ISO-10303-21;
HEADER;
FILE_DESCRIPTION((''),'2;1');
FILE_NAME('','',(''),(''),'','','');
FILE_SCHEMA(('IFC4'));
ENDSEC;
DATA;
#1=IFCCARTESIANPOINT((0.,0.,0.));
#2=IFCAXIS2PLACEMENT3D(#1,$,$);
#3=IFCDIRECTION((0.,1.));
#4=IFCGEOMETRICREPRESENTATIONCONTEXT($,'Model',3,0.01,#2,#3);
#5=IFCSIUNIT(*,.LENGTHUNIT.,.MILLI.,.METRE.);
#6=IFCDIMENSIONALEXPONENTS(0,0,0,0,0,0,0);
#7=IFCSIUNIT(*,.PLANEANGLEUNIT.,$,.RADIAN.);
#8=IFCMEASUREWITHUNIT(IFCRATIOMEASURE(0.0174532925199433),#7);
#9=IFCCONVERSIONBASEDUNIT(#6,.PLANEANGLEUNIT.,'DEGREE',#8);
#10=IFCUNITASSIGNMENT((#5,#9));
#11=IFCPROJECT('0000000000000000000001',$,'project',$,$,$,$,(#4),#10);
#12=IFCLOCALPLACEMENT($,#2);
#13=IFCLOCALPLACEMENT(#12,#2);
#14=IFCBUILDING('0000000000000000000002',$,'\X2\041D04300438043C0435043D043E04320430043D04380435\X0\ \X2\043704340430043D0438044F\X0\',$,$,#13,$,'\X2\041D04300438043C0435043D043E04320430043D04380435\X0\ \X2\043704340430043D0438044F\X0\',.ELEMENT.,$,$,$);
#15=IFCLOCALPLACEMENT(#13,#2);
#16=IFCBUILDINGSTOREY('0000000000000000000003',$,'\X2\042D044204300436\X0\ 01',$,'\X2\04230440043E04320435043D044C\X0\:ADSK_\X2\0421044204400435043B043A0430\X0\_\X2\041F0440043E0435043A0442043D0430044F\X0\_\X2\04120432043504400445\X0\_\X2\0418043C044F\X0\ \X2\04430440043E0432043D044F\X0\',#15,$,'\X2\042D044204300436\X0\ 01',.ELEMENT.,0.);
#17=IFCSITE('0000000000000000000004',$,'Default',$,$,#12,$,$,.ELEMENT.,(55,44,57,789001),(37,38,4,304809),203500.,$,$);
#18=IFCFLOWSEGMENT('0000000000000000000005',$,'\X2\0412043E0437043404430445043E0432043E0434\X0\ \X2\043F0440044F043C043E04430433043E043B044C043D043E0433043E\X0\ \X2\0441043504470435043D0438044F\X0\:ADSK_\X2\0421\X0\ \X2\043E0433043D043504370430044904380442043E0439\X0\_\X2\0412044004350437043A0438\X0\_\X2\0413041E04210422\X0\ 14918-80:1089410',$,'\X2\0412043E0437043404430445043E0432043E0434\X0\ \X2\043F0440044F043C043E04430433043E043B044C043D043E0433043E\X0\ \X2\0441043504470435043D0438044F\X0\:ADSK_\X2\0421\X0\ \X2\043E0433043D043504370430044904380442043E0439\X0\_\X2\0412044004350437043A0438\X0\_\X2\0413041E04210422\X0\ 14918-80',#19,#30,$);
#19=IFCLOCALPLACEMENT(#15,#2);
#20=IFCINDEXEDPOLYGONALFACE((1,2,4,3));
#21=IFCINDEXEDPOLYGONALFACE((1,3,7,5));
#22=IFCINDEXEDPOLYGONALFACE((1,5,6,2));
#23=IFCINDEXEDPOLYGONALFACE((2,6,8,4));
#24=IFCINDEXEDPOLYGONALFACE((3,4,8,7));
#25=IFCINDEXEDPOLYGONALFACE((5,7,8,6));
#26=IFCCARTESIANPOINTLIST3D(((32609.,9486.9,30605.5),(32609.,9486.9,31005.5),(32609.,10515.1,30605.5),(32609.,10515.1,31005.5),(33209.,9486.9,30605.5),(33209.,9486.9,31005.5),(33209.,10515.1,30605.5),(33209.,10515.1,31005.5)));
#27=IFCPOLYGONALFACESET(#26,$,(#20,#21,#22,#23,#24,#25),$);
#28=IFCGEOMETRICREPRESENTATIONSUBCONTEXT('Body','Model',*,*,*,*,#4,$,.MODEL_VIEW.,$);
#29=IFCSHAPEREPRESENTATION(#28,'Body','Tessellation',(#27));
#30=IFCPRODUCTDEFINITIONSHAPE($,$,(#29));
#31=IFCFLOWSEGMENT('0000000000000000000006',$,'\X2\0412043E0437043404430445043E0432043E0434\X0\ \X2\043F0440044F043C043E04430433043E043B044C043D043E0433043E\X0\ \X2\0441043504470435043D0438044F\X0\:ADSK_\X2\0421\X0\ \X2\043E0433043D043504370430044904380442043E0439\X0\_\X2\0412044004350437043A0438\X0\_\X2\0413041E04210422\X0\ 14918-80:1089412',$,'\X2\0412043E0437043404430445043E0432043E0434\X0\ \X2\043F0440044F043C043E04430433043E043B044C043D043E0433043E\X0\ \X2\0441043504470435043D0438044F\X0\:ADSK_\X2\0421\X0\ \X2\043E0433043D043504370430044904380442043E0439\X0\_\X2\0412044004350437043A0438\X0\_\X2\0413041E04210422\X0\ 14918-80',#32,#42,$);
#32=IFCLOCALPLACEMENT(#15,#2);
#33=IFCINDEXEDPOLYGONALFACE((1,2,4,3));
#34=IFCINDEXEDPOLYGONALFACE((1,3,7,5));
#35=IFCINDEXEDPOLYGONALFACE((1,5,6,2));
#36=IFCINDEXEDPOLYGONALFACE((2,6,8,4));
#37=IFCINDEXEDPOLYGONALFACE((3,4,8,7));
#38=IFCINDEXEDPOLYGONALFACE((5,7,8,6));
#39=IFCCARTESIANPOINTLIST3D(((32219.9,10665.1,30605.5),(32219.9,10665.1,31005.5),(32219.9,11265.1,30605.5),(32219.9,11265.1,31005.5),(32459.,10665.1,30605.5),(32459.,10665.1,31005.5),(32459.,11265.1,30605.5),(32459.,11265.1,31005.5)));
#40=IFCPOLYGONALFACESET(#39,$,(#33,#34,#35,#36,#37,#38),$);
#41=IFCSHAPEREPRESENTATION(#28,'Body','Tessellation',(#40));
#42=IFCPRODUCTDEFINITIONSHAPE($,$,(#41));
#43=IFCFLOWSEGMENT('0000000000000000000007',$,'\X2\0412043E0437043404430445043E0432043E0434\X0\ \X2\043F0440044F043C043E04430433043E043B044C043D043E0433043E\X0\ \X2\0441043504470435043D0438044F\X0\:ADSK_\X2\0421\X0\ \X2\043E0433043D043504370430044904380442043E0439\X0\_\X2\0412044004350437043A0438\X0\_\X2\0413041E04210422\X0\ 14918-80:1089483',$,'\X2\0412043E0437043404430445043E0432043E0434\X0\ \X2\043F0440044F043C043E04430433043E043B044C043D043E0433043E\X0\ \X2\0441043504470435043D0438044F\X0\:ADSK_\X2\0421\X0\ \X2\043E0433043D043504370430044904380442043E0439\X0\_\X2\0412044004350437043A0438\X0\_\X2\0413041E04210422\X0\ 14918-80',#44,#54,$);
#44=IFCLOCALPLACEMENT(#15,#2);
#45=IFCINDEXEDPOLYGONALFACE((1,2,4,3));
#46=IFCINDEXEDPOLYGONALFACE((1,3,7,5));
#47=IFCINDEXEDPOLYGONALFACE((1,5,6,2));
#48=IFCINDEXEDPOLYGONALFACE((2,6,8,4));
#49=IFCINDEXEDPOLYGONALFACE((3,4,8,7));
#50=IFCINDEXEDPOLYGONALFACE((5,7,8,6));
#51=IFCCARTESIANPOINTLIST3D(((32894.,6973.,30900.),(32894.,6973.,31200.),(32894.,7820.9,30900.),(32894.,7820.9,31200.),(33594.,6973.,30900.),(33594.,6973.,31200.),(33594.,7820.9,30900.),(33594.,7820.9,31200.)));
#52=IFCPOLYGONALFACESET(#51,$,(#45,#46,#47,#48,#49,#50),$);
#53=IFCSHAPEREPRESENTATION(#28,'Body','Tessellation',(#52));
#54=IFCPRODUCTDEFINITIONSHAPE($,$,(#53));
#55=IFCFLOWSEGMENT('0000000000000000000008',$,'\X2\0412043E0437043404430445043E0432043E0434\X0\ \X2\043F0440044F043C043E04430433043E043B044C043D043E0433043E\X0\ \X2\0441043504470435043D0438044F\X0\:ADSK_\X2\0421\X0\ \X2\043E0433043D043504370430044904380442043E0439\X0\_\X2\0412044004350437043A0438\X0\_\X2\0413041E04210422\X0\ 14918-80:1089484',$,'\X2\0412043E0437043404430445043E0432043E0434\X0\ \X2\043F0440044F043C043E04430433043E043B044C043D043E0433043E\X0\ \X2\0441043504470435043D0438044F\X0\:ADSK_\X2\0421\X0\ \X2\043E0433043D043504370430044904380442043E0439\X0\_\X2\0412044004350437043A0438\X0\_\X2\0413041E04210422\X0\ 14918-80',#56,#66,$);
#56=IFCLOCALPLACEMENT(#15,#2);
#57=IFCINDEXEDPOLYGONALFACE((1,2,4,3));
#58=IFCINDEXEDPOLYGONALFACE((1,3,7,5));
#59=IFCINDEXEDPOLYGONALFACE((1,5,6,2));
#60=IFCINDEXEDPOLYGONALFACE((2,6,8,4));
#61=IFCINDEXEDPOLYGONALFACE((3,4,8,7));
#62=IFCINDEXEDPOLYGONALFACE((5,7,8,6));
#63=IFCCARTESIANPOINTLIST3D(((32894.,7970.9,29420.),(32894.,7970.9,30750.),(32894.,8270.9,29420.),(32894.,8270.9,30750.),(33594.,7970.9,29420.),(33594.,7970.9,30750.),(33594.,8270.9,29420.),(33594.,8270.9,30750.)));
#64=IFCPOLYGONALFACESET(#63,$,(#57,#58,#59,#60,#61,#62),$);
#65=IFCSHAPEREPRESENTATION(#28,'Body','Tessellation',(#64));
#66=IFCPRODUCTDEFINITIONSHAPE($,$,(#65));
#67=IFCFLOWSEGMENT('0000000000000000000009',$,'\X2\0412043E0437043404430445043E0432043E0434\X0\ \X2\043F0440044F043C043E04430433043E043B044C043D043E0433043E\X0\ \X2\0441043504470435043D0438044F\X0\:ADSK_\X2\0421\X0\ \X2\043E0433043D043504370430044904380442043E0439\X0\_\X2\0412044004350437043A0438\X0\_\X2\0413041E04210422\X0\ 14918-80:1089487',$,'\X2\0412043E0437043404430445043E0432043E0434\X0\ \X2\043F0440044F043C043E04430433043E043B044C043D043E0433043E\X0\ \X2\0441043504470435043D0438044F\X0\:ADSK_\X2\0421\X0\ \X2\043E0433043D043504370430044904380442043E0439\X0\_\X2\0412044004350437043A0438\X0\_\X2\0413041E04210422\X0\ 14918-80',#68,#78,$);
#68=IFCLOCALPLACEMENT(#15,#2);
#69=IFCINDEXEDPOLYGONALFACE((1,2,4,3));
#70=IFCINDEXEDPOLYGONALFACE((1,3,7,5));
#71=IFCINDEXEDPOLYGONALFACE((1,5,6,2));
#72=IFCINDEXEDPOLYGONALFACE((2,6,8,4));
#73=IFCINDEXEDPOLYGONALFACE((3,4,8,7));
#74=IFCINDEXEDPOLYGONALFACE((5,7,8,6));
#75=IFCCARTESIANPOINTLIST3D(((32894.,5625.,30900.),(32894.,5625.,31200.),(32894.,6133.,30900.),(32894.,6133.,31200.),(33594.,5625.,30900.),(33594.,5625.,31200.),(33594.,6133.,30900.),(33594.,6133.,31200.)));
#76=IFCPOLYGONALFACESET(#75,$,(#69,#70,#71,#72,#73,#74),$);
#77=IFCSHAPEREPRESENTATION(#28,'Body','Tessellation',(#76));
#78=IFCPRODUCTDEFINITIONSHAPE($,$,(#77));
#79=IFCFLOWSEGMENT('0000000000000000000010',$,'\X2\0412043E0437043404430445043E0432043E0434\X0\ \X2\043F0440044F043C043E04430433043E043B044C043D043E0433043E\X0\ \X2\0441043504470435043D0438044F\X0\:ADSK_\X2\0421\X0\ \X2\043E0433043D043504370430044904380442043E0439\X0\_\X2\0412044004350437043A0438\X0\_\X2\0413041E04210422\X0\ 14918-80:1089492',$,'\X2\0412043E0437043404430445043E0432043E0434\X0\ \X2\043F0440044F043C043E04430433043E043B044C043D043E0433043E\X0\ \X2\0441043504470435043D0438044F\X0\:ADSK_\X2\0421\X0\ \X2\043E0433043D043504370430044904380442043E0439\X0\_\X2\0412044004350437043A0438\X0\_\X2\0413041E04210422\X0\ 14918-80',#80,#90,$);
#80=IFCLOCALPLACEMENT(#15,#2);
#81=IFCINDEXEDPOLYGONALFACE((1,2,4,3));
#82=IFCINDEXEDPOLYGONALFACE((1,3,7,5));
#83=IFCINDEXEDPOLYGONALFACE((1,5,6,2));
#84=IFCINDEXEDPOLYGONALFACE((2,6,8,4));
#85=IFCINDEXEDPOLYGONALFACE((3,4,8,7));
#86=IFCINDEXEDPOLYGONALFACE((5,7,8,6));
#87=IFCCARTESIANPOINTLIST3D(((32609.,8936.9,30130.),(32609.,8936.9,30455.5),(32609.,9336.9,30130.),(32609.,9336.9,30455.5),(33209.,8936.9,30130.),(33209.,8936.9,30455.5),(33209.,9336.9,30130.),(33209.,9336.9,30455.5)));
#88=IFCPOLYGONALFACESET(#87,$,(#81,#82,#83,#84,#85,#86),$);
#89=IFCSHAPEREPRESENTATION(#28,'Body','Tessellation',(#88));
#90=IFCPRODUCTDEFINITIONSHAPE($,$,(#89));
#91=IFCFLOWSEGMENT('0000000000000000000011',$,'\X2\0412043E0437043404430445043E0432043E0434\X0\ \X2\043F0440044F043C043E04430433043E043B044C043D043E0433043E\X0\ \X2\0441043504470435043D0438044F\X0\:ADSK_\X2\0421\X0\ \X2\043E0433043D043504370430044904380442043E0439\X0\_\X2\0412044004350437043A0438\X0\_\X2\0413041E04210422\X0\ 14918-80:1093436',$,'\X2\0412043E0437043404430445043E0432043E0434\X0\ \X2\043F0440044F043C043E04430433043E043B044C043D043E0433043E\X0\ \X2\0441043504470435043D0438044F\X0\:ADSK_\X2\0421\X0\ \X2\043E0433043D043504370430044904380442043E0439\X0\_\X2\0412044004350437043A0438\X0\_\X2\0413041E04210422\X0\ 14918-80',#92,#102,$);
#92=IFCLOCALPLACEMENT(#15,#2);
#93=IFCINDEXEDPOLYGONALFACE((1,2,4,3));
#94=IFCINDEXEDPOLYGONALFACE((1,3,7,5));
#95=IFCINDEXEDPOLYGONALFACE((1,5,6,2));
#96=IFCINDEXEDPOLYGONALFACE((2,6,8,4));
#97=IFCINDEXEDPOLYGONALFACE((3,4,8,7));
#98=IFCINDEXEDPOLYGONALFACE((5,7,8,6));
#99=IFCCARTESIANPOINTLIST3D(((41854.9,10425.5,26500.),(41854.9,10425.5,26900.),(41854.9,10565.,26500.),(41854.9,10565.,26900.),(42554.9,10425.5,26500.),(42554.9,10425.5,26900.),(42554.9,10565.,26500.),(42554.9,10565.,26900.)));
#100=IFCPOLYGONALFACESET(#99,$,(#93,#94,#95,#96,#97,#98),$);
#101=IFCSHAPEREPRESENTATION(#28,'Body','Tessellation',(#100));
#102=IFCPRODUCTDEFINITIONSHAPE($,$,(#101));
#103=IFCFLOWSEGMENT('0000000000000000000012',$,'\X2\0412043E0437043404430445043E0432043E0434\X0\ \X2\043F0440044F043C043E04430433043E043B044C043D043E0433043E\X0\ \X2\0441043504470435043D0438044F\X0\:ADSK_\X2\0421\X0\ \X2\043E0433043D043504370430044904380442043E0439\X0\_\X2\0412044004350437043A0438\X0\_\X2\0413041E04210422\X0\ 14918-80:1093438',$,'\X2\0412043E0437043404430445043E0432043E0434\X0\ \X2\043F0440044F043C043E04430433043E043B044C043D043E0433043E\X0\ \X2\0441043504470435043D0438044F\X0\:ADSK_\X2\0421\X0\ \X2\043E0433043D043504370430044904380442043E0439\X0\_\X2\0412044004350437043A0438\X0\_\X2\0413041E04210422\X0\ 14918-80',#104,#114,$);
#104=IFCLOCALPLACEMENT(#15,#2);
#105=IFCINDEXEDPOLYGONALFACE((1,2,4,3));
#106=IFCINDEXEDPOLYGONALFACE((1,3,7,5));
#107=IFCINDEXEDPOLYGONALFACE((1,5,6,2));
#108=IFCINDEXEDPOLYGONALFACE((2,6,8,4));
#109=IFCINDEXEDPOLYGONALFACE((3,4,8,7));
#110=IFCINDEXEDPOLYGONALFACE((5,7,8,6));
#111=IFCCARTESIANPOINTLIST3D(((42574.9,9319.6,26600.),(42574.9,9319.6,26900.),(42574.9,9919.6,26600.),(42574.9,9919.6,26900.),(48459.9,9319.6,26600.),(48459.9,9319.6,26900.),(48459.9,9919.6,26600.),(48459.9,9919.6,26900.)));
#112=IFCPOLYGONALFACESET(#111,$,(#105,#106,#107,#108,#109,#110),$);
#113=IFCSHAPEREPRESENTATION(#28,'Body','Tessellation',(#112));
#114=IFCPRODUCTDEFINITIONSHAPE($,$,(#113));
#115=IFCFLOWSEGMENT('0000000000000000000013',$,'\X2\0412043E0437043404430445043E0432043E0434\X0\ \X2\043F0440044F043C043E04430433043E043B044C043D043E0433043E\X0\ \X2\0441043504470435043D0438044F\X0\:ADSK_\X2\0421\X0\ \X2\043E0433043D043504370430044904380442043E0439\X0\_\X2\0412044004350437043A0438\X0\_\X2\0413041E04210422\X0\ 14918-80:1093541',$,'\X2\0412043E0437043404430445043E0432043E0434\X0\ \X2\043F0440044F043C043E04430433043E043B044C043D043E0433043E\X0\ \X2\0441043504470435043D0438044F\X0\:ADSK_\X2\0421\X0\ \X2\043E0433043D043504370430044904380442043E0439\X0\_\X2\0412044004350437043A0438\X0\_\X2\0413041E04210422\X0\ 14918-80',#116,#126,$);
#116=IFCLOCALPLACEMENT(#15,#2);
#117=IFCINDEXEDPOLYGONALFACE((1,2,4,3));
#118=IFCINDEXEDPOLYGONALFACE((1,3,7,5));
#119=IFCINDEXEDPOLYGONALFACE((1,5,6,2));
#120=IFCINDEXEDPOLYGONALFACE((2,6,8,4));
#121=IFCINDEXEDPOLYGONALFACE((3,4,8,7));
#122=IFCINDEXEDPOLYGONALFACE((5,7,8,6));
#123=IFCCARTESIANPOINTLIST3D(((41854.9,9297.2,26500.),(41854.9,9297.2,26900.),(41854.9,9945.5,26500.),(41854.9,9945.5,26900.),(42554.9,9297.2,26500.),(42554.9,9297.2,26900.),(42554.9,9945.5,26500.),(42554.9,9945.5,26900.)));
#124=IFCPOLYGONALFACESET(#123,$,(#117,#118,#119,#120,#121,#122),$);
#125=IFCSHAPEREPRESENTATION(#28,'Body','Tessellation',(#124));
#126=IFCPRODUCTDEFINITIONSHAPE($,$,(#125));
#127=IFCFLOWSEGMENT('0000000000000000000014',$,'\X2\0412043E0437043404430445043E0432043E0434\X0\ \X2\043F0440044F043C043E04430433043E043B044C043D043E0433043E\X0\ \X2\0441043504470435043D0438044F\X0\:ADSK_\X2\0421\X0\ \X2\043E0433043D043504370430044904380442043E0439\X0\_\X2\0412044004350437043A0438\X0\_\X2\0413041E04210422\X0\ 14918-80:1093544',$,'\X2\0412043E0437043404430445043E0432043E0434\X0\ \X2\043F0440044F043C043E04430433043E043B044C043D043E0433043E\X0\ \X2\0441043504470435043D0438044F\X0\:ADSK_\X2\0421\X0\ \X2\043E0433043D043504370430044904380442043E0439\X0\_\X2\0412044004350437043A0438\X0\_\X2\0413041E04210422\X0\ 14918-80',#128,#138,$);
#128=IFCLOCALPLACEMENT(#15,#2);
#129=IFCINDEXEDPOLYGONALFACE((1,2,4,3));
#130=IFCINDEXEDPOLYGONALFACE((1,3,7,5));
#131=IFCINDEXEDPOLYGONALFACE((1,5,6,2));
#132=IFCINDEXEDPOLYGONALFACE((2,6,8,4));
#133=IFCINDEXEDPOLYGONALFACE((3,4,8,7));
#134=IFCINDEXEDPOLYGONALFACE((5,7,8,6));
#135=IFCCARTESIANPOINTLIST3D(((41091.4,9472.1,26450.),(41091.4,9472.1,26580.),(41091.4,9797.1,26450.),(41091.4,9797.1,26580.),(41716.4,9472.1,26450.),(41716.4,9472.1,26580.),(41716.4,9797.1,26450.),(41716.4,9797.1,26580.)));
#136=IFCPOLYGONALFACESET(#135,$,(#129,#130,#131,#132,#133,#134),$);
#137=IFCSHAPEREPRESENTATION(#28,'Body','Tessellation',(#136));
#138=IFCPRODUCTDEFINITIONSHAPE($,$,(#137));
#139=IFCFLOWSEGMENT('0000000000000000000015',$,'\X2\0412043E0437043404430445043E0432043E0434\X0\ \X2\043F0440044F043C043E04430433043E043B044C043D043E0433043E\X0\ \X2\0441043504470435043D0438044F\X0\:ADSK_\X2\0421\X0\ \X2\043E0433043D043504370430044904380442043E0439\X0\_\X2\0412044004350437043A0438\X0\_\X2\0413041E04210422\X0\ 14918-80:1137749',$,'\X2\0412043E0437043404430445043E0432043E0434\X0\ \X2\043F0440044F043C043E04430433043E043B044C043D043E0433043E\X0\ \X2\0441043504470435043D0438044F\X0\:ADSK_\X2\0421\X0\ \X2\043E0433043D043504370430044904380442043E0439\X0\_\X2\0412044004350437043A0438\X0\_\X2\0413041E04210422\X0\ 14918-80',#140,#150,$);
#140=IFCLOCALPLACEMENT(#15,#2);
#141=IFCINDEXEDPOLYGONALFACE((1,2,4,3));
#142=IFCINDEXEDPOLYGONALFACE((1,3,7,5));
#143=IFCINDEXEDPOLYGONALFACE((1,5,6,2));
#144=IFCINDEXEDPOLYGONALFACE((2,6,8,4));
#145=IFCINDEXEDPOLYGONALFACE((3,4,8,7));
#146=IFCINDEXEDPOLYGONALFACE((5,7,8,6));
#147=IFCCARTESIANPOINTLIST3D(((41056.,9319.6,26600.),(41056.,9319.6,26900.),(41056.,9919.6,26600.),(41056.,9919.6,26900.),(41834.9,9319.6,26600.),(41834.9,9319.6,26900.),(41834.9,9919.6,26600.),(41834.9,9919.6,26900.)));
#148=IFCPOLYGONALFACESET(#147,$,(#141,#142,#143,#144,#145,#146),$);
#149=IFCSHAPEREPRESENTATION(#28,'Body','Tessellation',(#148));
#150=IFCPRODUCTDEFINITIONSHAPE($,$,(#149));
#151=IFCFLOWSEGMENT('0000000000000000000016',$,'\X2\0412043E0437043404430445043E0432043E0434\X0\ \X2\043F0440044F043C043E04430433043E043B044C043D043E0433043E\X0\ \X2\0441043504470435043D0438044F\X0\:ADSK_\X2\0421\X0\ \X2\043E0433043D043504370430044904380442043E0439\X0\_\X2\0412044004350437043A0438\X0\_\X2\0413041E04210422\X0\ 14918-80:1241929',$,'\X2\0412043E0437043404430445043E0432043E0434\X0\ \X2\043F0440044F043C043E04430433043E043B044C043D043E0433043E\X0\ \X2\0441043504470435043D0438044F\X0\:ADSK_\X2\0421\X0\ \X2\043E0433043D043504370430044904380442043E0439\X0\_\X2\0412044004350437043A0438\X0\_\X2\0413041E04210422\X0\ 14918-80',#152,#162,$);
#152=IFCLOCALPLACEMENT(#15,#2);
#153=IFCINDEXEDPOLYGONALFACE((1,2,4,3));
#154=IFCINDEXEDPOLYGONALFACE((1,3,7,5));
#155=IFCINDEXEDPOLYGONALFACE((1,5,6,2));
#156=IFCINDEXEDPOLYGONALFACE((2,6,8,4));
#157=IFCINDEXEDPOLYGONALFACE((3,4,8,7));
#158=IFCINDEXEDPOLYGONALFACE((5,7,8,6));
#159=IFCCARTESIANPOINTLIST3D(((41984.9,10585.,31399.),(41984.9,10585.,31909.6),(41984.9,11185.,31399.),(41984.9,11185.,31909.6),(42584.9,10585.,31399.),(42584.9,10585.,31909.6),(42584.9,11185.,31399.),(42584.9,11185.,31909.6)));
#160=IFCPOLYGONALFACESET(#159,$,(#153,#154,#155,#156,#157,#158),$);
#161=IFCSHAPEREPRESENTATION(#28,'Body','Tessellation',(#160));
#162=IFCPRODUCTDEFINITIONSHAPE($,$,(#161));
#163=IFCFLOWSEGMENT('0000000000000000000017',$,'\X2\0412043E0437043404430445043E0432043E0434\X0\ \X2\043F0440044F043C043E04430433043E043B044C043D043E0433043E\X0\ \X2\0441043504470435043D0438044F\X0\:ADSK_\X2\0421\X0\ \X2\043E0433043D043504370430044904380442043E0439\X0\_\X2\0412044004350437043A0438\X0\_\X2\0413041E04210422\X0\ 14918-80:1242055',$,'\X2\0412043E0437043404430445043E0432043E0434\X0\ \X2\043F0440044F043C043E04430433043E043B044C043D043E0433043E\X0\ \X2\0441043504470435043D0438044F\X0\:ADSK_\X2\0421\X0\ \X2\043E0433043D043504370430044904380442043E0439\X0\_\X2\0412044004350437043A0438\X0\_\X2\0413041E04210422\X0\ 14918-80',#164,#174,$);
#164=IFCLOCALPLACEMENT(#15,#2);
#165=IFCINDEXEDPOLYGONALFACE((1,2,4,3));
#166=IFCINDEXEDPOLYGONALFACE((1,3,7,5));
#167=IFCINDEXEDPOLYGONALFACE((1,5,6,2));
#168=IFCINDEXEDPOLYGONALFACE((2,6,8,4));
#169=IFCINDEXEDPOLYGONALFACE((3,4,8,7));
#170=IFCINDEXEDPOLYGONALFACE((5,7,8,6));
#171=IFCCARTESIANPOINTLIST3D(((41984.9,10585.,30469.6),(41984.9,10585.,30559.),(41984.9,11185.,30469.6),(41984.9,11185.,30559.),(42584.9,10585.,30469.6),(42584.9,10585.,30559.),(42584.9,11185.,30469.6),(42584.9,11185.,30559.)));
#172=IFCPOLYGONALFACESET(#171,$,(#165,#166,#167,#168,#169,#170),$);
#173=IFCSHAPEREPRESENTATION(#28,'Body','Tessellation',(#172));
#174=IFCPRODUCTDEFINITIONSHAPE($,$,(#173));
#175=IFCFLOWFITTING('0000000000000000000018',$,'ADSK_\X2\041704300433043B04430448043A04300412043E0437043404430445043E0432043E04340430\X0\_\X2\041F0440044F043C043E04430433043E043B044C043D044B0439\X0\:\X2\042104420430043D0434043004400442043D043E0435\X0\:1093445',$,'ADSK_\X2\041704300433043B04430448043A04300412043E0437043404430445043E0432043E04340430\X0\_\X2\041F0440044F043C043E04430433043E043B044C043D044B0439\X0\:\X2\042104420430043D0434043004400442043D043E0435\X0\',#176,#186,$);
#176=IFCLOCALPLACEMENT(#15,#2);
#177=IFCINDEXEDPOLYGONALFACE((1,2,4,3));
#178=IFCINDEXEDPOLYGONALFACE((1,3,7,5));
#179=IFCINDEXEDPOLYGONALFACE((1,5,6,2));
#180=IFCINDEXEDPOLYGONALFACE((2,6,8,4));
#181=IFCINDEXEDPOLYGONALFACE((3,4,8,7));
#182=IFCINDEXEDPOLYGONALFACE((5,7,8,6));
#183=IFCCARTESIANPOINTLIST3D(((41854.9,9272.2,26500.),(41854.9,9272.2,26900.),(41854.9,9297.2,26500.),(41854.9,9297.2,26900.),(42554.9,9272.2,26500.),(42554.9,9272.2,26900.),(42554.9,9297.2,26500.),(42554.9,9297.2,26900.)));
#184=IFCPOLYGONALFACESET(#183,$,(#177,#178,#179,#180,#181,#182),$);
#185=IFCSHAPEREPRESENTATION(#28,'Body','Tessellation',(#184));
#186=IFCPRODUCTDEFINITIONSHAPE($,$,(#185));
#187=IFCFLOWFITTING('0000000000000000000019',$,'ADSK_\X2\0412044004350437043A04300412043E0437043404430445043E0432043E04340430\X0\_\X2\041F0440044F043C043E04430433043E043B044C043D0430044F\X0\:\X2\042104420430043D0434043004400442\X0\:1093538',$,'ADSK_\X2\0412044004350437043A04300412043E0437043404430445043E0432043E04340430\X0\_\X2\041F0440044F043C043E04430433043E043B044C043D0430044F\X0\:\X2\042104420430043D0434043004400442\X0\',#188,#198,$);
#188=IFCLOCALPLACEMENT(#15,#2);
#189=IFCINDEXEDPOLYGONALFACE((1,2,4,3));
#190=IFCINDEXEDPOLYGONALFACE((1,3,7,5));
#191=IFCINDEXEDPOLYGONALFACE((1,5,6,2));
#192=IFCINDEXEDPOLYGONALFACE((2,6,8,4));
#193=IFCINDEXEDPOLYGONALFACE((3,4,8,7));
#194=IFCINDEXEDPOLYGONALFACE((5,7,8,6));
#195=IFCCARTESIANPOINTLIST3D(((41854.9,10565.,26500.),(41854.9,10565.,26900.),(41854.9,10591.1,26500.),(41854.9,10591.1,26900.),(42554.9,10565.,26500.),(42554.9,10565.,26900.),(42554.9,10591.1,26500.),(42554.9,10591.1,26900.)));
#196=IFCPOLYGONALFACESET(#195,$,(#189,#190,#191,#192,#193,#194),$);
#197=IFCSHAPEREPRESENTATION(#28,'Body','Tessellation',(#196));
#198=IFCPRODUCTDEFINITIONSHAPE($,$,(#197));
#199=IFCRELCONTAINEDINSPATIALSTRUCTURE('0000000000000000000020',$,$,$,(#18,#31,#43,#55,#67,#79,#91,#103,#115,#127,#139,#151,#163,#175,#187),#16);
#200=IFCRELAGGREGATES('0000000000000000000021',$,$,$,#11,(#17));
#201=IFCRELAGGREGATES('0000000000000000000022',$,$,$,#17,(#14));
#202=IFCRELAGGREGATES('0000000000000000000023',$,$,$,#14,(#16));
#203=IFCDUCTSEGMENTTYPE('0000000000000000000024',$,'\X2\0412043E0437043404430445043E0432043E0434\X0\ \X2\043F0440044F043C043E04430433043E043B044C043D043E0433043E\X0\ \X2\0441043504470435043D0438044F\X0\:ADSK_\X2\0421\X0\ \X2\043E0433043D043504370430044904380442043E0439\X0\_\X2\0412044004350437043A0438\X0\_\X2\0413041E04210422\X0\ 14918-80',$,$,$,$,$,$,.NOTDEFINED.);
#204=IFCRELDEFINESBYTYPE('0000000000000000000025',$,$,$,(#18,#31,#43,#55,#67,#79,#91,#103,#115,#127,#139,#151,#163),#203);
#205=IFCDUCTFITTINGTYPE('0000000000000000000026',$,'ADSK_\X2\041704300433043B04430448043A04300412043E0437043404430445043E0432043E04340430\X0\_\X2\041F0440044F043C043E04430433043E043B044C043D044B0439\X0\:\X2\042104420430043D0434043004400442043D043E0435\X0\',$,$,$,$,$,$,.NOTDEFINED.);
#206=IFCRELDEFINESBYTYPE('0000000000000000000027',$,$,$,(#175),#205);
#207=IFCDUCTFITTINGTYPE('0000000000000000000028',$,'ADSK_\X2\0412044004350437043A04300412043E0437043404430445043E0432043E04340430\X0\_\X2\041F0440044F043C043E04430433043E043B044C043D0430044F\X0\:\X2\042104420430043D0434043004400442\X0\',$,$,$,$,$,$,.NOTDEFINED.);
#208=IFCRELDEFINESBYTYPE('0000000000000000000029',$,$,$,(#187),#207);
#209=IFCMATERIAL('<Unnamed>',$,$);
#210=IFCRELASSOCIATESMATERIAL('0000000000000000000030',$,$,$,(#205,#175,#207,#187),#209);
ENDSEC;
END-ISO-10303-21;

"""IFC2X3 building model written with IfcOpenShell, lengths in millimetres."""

from ifc_helpers import new_model, entity, si_unit, converted_unit, direction, frame, frame_2d, origin, origin_2d_with_axis, place, context, subcontext, project, spatial, rectangle, extrude, source, transform, mapped, material, type_object, type_shapes, element, save


model = new_model("IFC2X3")

# Units and contexts
model_context = context("Model", 3, precision=0.01, world=origin(), true_north=direction((0.0, 1.0)))
body_context = subcontext(model_context, "Body", "Model", "MODEL_VIEW")
ifc_project = project(units=[si_unit("LENGTHUNIT", "METRE", prefix="MILLI"), converted_unit("PLANEANGLEUNIT", "DEGREE", entity("IfcRatioMeasure", 0.0174532925199433), si_unit("PLANEANGLEUNIT", "RADIAN"), dimensions=[0, 0, 0, 0, 0, 0, 0])], contexts=[model_context])

# Site, building, storey
site_placement = place(None, frame((0.0, 0.0, 0.0)))
site = spatial("IfcSite", under=ifc_project, at=site_placement, Name="Default", CompositionType="ELEMENT", RefLatitude=(55, 44, 57, 789001), RefLongitude=(37, 38, 4, 304809), RefElevation=203500.0)
building_placement = place(site_placement, origin())
building = spatial("IfcBuilding", under=site, at=building_placement, Name="Наименование здания", LongName="Наименование здания", CompositionType="ELEMENT")
storey_placement = place(building_placement, origin())
storey = spatial("IfcBuildingStorey", under=building, at=storey_placement, Name="Этаж 01", ObjectType="Уровень:ADSK_Стрелка_Проектная_Вверх_Имя уровня", LongName="Этаж 01", CompositionType="ELEMENT", Elevation=0.0)

# Flow segments
duct_segment_type = type_object("IfcDuctSegmentType", Name="Воздуховод прямоугольного сечения:ADSK_С огнезащитой_Врезки_ГОСТ 14918-80", PredefinedType="NOTDEFINED")
flow_segment_1_placement = place(storey_placement, frame((32609.0, 9486.9, 30605.5)))
element("IfcFlowSegment", 1, at=flow_segment_1_placement, inside=storey, type_object=duct_segment_type, Name="Воздуховод прямоугольного сечения:ADSK_С огнезащитой_Врезки_ГОСТ 14918-80:1089410", ObjectType="Воздуховод прямоугольного сечения:ADSK_С огнезащитой_Врезки_ГОСТ 14918-80", context=body_context, shape_type="SweptSolid", body=[
    extrude(rectangle(XDim=1028.2, YDim=600.0, at=frame_2d((0.0, 0.0), x_axis=(1.0, 0.0))), frame((300.0, 514.1, 0.0), z_axis=(0.0, 0.0, 1.0), x_axis=(0.0, 1.0, 0.0)), (0.0, 0.0, 1.0), 400.0),
])
flow_segment_2_placement = place(storey_placement, frame((32219.9, 10665.1, 30605.5)))
element("IfcFlowSegment", 2, at=flow_segment_2_placement, inside=storey, type_object=duct_segment_type, Name="Воздуховод прямоугольного сечения:ADSK_С огнезащитой_Врезки_ГОСТ 14918-80:1089412", ObjectType="Воздуховод прямоугольного сечения:ADSK_С огнезащитой_Врезки_ГОСТ 14918-80", context=body_context, shape_type="SweptSolid", body=[
    extrude(rectangle(XDim=239.1, YDim=600.0, at=frame_2d((0.0, 0.0), x_axis=(1.0, 0.0))), frame((119.6, 300.0, 0.0)), (0.0, 0.0, 1.0), 400.0),
])
flow_segment_3_placement = place(storey_placement, frame((32894.0, 6973.0, 30900.0)))
element("IfcFlowSegment", 3, at=flow_segment_3_placement, inside=storey, type_object=duct_segment_type, Name="Воздуховод прямоугольного сечения:ADSK_С огнезащитой_Врезки_ГОСТ 14918-80:1089483", ObjectType="Воздуховод прямоугольного сечения:ADSK_С огнезащитой_Врезки_ГОСТ 14918-80", context=body_context, shape_type="SweptSolid", body=[
    extrude(rectangle(XDim=848.0, YDim=700.0, at=frame_2d((0.0, 0.0), x_axis=(1.0, 0.0))), frame((350.0, 424.0, 0.0), z_axis=(0.0, 0.0, 1.0), x_axis=(0.0, -1.0, 0.0)), (0.0, 0.0, 1.0), 300.0),
])
flow_segment_4_placement = place(storey_placement, frame((32894.0, 7970.9, 29420.0)))
element("IfcFlowSegment", 4, at=flow_segment_4_placement, inside=storey, type_object=duct_segment_type, Name="Воздуховод прямоугольного сечения:ADSK_С огнезащитой_Врезки_ГОСТ 14918-80:1089484", ObjectType="Воздуховод прямоугольного сечения:ADSK_С огнезащитой_Врезки_ГОСТ 14918-80", context=body_context, shape_type="SweptSolid", body=[
    extrude(rectangle(XDim=300.0, YDim=700.0, at=frame_2d((0.0, 0.0), x_axis=(1.0, 0.0))), frame((350.0, 150.0, 0.0), z_axis=(0.0, 0.0, 1.0), x_axis=(0.0, 1.0, 0.0)), (0.0, 0.0, 1.0), 1330.0),
])
flow_segment_5_placement = place(storey_placement, frame((32894.0, 5625.0, 30900.0)))
element("IfcFlowSegment", 5, at=flow_segment_5_placement, inside=storey, type_object=duct_segment_type, Name="Воздуховод прямоугольного сечения:ADSK_С огнезащитой_Врезки_ГОСТ 14918-80:1089487", ObjectType="Воздуховод прямоугольного сечения:ADSK_С огнезащитой_Врезки_ГОСТ 14918-80", context=body_context, shape_type="SweptSolid", body=[
    extrude(rectangle(XDim=508.0, YDim=700.0, at=frame_2d((0.0, 0.0), x_axis=(1.0, 0.0))), frame((350.0, 254.0, 0.0), z_axis=(0.0, 0.0, 1.0), x_axis=(0.0, -1.0, 0.0)), (0.0, 0.0, 1.0), 300.0),
])
flow_segment_6_placement = place(storey_placement, frame((32609.0, 8936.9, 30130.0)))
element("IfcFlowSegment", 6, at=flow_segment_6_placement, inside=storey, type_object=duct_segment_type, Name="Воздуховод прямоугольного сечения:ADSK_С огнезащитой_Врезки_ГОСТ 14918-80:1089492", ObjectType="Воздуховод прямоугольного сечения:ADSK_С огнезащитой_Врезки_ГОСТ 14918-80", context=body_context, shape_type="SweptSolid", body=[
    extrude(rectangle(XDim=600.0, YDim=400.0, at=origin_2d_with_axis()), frame((300.0, 200.0, 0.0)), (0.0, 0.0, 1.0), 325.5),
])
flow_segment_7_placement = place(storey_placement, frame((41854.9, 10425.5, 26500.0)))
element("IfcFlowSegment", 7, at=flow_segment_7_placement, inside=storey, type_object=duct_segment_type, Name="Воздуховод прямоугольного сечения:ADSK_С огнезащитой_Врезки_ГОСТ 14918-80:1093436", ObjectType="Воздуховод прямоугольного сечения:ADSK_С огнезащитой_Врезки_ГОСТ 14918-80", context=body_context, shape_type="SweptSolid", body=[
    extrude(rectangle(XDim=139.5, YDim=700.0, at=origin_2d_with_axis()), frame((350.0, 69.7, 0.0), z_axis=(0.0, 0.0, 1.0), x_axis=(0.0, 1.0, 0.0)), (0.0, 0.0, 1.0), 400.0),
])
flow_segment_8_placement = place(storey_placement, frame((42574.9, 9319.6, 26600.0)))
element("IfcFlowSegment", 8, at=flow_segment_8_placement, inside=storey, type_object=duct_segment_type, Name="Воздуховод прямоугольного сечения:ADSK_С огнезащитой_Врезки_ГОСТ 14918-80:1093438", ObjectType="Воздуховод прямоугольного сечения:ADSK_С огнезащитой_Врезки_ГОСТ 14918-80", context=body_context, shape_type="SweptSolid", body=[
    extrude(rectangle(XDim=5885.0, YDim=600.0, at=frame_2d((0.0, 0.0), x_axis=(1.0, 0.0))), frame((2942.5, 300.0, 0.0), z_axis=(0.0, 0.0, 1.0), x_axis=(-1.0, 0.0, 0.0)), (0.0, 0.0, 1.0), 300.0),
])
flow_segment_9_placement = place(storey_placement, frame((41854.9, 9297.2, 26500.0)))
element("IfcFlowSegment", 9, at=flow_segment_9_placement, inside=storey, type_object=duct_segment_type, Name="Воздуховод прямоугольного сечения:ADSK_С огнезащитой_Врезки_ГОСТ 14918-80:1093541", ObjectType="Воздуховод прямоугольного сечения:ADSK_С огнезащитой_Врезки_ГОСТ 14918-80", context=body_context, shape_type="SweptSolid", body=[
    extrude(rectangle(XDim=648.3, YDim=700.0, at=frame_2d((0.0, 0.0), x_axis=(1.0, 0.0))), frame((350.0, 324.1, 0.0), z_axis=(0.0, 0.0, 1.0), x_axis=(0.0, 1.0, 0.0)), (0.0, 0.0, 1.0), 400.0),
])
flow_segment_10_placement = place(storey_placement, frame((41091.4, 9472.1, 26450.0)))
element("IfcFlowSegment", 10, at=flow_segment_10_placement, inside=storey, type_object=duct_segment_type, Name="Воздуховод прямоугольного сечения:ADSK_С огнезащитой_Врезки_ГОСТ 14918-80:1093544", ObjectType="Воздуховод прямоугольного сечения:ADSK_С огнезащитой_Врезки_ГОСТ 14918-80", context=body_context, shape_type="SweptSolid", body=[
    extrude(rectangle(XDim=625.0, YDim=325.0, at=origin_2d_with_axis()), frame((312.5, 162.5, 0.0)), (0.0, 0.0, 1.0), 130.0),
])
flow_segment_11_placement = place(storey_placement, frame((41056.0, 9319.6, 26600.0)))
element("IfcFlowSegment", 11, at=flow_segment_11_placement, inside=storey, type_object=duct_segment_type, Name="Воздуховод прямоугольного сечения:ADSK_С огнезащитой_Врезки_ГОСТ 14918-80:1137749", ObjectType="Воздуховод прямоугольного сечения:ADSK_С огнезащитой_Врезки_ГОСТ 14918-80", context=body_context, shape_type="SweptSolid", body=[
    extrude(rectangle(XDim=778.9, YDim=600.0, at=frame_2d((0.0, 0.0), x_axis=(1.0, 0.0))), frame((389.4, 300.0, 0.0)), (0.0, 0.0, 1.0), 300.0),
])
flow_segment_12_placement = place(storey_placement, frame((41984.9, 10585.0, 31399.0)))
element("IfcFlowSegment", 12, at=flow_segment_12_placement, inside=storey, type_object=duct_segment_type, Name="Воздуховод прямоугольного сечения:ADSK_С огнезащитой_Врезки_ГОСТ 14918-80:1241929", ObjectType="Воздуховод прямоугольного сечения:ADSK_С огнезащитой_Врезки_ГОСТ 14918-80", context=body_context, shape_type="SweptSolid", body=[
    extrude(rectangle(XDim=600.0, YDim=600.0, at=frame_2d((0.0, 0.0), x_axis=(1.0, 0.0))), frame((300.0, 300.0, 0.0)), (0.0, 0.0, 1.0), 510.6),
])
flow_segment_13_placement = place(storey_placement, frame((41984.9, 10585.0, 30469.6)))
element("IfcFlowSegment", 13, at=flow_segment_13_placement, inside=storey, type_object=duct_segment_type, Name="Воздуховод прямоугольного сечения:ADSK_С огнезащитой_Врезки_ГОСТ 14918-80:1242055", ObjectType="Воздуховод прямоугольного сечения:ADSK_С огнезащитой_Врезки_ГОСТ 14918-80", context=body_context, shape_type="SweptSolid", body=[
    extrude(rectangle(XDim=600.0, YDim=600.0, at=frame_2d((0.0, 0.0), x_axis=(1.0, 0.0))), frame((300.0, 300.0, 0.0)), (0.0, 0.0, 1.0), 89.4),
])

# Flow fittings
ifc_material_1 = material(Name="<Unnamed>")
duct_fitting_type_1 = type_object("IfcDuctFittingType", Name="ADSK_ЗаглушкаВоздуховода_Прямоугольный:Стандартное", PredefinedType="NOTDEFINED", material=ifc_material_1)
shared_shape_1 = source(origin(), body_context, "Body", "SweptSolid", [
    extrude(rectangle(XDim=25.0, YDim=700.0, at=frame_2d((0.0, 0.0), x_axis=(1.0, 0.0))), frame((12.5, 0.0, -200.0)), (0.0, 0.0, 1.0), 400.0),
])
type_shapes(duct_fitting_type_1, [shared_shape_1])
flow_fitting_1_placement = place(storey_placement, frame((42204.9, 9297.2, 26700.0), z_axis=(0.0, 0.0, 1.0), x_axis=(0.0, -1.0, 0.0)))
element("IfcFlowFitting", 14, at=flow_fitting_1_placement, inside=storey, type_object=duct_fitting_type_1, material=ifc_material_1, Name="ADSK_ЗаглушкаВоздуховода_Прямоугольный:Стандартное:1093445", ObjectType="ADSK_ЗаглушкаВоздуховода_Прямоугольный:Стандартное", context=body_context, shape_type="MappedRepresentation", body=[
    mapped(shared_shape_1, transform((0.0, 0.0, 0.0), scale=1.0)),
])
duct_fitting_type_2 = type_object("IfcDuctFittingType", Name="ADSK_ВрезкаВоздуховода_Прямоугольная:Стандарт", PredefinedType="NOTDEFINED", material=ifc_material_1)
shared_shape_2 = source(origin(), body_context, "Body", "SweptSolid", [
    extrude(rectangle(XDim=26.1, YDim=400.0, at=frame_2d((0.0, 0.0), x_axis=(1.0, 0.0))), frame((7.0, 0.0, -350.0)), (0.0, 0.0, 1.0), 700.0),
])
type_shapes(duct_fitting_type_2, [shared_shape_2])
flow_fitting_2_placement = place(storey_placement, frame((42204.9, 10585.0, 26700.0), z_axis=(-1.0, 0.0, 0.0), x_axis=(0.0, -1.0, 0.0)))
element("IfcFlowFitting", 15, at=flow_fitting_2_placement, inside=storey, type_object=duct_fitting_type_2, material=ifc_material_1, Name="ADSK_ВрезкаВоздуховода_Прямоугольная:Стандарт:1093538", ObjectType="ADSK_ВрезкаВоздуховода_Прямоугольная:Стандарт", context=body_context, shape_type="MappedRepresentation", body=[
    mapped(shared_shape_2, transform((0.0, 0.0, 0.0), scale=1.0)),
])

save(model, "model.ifc")
